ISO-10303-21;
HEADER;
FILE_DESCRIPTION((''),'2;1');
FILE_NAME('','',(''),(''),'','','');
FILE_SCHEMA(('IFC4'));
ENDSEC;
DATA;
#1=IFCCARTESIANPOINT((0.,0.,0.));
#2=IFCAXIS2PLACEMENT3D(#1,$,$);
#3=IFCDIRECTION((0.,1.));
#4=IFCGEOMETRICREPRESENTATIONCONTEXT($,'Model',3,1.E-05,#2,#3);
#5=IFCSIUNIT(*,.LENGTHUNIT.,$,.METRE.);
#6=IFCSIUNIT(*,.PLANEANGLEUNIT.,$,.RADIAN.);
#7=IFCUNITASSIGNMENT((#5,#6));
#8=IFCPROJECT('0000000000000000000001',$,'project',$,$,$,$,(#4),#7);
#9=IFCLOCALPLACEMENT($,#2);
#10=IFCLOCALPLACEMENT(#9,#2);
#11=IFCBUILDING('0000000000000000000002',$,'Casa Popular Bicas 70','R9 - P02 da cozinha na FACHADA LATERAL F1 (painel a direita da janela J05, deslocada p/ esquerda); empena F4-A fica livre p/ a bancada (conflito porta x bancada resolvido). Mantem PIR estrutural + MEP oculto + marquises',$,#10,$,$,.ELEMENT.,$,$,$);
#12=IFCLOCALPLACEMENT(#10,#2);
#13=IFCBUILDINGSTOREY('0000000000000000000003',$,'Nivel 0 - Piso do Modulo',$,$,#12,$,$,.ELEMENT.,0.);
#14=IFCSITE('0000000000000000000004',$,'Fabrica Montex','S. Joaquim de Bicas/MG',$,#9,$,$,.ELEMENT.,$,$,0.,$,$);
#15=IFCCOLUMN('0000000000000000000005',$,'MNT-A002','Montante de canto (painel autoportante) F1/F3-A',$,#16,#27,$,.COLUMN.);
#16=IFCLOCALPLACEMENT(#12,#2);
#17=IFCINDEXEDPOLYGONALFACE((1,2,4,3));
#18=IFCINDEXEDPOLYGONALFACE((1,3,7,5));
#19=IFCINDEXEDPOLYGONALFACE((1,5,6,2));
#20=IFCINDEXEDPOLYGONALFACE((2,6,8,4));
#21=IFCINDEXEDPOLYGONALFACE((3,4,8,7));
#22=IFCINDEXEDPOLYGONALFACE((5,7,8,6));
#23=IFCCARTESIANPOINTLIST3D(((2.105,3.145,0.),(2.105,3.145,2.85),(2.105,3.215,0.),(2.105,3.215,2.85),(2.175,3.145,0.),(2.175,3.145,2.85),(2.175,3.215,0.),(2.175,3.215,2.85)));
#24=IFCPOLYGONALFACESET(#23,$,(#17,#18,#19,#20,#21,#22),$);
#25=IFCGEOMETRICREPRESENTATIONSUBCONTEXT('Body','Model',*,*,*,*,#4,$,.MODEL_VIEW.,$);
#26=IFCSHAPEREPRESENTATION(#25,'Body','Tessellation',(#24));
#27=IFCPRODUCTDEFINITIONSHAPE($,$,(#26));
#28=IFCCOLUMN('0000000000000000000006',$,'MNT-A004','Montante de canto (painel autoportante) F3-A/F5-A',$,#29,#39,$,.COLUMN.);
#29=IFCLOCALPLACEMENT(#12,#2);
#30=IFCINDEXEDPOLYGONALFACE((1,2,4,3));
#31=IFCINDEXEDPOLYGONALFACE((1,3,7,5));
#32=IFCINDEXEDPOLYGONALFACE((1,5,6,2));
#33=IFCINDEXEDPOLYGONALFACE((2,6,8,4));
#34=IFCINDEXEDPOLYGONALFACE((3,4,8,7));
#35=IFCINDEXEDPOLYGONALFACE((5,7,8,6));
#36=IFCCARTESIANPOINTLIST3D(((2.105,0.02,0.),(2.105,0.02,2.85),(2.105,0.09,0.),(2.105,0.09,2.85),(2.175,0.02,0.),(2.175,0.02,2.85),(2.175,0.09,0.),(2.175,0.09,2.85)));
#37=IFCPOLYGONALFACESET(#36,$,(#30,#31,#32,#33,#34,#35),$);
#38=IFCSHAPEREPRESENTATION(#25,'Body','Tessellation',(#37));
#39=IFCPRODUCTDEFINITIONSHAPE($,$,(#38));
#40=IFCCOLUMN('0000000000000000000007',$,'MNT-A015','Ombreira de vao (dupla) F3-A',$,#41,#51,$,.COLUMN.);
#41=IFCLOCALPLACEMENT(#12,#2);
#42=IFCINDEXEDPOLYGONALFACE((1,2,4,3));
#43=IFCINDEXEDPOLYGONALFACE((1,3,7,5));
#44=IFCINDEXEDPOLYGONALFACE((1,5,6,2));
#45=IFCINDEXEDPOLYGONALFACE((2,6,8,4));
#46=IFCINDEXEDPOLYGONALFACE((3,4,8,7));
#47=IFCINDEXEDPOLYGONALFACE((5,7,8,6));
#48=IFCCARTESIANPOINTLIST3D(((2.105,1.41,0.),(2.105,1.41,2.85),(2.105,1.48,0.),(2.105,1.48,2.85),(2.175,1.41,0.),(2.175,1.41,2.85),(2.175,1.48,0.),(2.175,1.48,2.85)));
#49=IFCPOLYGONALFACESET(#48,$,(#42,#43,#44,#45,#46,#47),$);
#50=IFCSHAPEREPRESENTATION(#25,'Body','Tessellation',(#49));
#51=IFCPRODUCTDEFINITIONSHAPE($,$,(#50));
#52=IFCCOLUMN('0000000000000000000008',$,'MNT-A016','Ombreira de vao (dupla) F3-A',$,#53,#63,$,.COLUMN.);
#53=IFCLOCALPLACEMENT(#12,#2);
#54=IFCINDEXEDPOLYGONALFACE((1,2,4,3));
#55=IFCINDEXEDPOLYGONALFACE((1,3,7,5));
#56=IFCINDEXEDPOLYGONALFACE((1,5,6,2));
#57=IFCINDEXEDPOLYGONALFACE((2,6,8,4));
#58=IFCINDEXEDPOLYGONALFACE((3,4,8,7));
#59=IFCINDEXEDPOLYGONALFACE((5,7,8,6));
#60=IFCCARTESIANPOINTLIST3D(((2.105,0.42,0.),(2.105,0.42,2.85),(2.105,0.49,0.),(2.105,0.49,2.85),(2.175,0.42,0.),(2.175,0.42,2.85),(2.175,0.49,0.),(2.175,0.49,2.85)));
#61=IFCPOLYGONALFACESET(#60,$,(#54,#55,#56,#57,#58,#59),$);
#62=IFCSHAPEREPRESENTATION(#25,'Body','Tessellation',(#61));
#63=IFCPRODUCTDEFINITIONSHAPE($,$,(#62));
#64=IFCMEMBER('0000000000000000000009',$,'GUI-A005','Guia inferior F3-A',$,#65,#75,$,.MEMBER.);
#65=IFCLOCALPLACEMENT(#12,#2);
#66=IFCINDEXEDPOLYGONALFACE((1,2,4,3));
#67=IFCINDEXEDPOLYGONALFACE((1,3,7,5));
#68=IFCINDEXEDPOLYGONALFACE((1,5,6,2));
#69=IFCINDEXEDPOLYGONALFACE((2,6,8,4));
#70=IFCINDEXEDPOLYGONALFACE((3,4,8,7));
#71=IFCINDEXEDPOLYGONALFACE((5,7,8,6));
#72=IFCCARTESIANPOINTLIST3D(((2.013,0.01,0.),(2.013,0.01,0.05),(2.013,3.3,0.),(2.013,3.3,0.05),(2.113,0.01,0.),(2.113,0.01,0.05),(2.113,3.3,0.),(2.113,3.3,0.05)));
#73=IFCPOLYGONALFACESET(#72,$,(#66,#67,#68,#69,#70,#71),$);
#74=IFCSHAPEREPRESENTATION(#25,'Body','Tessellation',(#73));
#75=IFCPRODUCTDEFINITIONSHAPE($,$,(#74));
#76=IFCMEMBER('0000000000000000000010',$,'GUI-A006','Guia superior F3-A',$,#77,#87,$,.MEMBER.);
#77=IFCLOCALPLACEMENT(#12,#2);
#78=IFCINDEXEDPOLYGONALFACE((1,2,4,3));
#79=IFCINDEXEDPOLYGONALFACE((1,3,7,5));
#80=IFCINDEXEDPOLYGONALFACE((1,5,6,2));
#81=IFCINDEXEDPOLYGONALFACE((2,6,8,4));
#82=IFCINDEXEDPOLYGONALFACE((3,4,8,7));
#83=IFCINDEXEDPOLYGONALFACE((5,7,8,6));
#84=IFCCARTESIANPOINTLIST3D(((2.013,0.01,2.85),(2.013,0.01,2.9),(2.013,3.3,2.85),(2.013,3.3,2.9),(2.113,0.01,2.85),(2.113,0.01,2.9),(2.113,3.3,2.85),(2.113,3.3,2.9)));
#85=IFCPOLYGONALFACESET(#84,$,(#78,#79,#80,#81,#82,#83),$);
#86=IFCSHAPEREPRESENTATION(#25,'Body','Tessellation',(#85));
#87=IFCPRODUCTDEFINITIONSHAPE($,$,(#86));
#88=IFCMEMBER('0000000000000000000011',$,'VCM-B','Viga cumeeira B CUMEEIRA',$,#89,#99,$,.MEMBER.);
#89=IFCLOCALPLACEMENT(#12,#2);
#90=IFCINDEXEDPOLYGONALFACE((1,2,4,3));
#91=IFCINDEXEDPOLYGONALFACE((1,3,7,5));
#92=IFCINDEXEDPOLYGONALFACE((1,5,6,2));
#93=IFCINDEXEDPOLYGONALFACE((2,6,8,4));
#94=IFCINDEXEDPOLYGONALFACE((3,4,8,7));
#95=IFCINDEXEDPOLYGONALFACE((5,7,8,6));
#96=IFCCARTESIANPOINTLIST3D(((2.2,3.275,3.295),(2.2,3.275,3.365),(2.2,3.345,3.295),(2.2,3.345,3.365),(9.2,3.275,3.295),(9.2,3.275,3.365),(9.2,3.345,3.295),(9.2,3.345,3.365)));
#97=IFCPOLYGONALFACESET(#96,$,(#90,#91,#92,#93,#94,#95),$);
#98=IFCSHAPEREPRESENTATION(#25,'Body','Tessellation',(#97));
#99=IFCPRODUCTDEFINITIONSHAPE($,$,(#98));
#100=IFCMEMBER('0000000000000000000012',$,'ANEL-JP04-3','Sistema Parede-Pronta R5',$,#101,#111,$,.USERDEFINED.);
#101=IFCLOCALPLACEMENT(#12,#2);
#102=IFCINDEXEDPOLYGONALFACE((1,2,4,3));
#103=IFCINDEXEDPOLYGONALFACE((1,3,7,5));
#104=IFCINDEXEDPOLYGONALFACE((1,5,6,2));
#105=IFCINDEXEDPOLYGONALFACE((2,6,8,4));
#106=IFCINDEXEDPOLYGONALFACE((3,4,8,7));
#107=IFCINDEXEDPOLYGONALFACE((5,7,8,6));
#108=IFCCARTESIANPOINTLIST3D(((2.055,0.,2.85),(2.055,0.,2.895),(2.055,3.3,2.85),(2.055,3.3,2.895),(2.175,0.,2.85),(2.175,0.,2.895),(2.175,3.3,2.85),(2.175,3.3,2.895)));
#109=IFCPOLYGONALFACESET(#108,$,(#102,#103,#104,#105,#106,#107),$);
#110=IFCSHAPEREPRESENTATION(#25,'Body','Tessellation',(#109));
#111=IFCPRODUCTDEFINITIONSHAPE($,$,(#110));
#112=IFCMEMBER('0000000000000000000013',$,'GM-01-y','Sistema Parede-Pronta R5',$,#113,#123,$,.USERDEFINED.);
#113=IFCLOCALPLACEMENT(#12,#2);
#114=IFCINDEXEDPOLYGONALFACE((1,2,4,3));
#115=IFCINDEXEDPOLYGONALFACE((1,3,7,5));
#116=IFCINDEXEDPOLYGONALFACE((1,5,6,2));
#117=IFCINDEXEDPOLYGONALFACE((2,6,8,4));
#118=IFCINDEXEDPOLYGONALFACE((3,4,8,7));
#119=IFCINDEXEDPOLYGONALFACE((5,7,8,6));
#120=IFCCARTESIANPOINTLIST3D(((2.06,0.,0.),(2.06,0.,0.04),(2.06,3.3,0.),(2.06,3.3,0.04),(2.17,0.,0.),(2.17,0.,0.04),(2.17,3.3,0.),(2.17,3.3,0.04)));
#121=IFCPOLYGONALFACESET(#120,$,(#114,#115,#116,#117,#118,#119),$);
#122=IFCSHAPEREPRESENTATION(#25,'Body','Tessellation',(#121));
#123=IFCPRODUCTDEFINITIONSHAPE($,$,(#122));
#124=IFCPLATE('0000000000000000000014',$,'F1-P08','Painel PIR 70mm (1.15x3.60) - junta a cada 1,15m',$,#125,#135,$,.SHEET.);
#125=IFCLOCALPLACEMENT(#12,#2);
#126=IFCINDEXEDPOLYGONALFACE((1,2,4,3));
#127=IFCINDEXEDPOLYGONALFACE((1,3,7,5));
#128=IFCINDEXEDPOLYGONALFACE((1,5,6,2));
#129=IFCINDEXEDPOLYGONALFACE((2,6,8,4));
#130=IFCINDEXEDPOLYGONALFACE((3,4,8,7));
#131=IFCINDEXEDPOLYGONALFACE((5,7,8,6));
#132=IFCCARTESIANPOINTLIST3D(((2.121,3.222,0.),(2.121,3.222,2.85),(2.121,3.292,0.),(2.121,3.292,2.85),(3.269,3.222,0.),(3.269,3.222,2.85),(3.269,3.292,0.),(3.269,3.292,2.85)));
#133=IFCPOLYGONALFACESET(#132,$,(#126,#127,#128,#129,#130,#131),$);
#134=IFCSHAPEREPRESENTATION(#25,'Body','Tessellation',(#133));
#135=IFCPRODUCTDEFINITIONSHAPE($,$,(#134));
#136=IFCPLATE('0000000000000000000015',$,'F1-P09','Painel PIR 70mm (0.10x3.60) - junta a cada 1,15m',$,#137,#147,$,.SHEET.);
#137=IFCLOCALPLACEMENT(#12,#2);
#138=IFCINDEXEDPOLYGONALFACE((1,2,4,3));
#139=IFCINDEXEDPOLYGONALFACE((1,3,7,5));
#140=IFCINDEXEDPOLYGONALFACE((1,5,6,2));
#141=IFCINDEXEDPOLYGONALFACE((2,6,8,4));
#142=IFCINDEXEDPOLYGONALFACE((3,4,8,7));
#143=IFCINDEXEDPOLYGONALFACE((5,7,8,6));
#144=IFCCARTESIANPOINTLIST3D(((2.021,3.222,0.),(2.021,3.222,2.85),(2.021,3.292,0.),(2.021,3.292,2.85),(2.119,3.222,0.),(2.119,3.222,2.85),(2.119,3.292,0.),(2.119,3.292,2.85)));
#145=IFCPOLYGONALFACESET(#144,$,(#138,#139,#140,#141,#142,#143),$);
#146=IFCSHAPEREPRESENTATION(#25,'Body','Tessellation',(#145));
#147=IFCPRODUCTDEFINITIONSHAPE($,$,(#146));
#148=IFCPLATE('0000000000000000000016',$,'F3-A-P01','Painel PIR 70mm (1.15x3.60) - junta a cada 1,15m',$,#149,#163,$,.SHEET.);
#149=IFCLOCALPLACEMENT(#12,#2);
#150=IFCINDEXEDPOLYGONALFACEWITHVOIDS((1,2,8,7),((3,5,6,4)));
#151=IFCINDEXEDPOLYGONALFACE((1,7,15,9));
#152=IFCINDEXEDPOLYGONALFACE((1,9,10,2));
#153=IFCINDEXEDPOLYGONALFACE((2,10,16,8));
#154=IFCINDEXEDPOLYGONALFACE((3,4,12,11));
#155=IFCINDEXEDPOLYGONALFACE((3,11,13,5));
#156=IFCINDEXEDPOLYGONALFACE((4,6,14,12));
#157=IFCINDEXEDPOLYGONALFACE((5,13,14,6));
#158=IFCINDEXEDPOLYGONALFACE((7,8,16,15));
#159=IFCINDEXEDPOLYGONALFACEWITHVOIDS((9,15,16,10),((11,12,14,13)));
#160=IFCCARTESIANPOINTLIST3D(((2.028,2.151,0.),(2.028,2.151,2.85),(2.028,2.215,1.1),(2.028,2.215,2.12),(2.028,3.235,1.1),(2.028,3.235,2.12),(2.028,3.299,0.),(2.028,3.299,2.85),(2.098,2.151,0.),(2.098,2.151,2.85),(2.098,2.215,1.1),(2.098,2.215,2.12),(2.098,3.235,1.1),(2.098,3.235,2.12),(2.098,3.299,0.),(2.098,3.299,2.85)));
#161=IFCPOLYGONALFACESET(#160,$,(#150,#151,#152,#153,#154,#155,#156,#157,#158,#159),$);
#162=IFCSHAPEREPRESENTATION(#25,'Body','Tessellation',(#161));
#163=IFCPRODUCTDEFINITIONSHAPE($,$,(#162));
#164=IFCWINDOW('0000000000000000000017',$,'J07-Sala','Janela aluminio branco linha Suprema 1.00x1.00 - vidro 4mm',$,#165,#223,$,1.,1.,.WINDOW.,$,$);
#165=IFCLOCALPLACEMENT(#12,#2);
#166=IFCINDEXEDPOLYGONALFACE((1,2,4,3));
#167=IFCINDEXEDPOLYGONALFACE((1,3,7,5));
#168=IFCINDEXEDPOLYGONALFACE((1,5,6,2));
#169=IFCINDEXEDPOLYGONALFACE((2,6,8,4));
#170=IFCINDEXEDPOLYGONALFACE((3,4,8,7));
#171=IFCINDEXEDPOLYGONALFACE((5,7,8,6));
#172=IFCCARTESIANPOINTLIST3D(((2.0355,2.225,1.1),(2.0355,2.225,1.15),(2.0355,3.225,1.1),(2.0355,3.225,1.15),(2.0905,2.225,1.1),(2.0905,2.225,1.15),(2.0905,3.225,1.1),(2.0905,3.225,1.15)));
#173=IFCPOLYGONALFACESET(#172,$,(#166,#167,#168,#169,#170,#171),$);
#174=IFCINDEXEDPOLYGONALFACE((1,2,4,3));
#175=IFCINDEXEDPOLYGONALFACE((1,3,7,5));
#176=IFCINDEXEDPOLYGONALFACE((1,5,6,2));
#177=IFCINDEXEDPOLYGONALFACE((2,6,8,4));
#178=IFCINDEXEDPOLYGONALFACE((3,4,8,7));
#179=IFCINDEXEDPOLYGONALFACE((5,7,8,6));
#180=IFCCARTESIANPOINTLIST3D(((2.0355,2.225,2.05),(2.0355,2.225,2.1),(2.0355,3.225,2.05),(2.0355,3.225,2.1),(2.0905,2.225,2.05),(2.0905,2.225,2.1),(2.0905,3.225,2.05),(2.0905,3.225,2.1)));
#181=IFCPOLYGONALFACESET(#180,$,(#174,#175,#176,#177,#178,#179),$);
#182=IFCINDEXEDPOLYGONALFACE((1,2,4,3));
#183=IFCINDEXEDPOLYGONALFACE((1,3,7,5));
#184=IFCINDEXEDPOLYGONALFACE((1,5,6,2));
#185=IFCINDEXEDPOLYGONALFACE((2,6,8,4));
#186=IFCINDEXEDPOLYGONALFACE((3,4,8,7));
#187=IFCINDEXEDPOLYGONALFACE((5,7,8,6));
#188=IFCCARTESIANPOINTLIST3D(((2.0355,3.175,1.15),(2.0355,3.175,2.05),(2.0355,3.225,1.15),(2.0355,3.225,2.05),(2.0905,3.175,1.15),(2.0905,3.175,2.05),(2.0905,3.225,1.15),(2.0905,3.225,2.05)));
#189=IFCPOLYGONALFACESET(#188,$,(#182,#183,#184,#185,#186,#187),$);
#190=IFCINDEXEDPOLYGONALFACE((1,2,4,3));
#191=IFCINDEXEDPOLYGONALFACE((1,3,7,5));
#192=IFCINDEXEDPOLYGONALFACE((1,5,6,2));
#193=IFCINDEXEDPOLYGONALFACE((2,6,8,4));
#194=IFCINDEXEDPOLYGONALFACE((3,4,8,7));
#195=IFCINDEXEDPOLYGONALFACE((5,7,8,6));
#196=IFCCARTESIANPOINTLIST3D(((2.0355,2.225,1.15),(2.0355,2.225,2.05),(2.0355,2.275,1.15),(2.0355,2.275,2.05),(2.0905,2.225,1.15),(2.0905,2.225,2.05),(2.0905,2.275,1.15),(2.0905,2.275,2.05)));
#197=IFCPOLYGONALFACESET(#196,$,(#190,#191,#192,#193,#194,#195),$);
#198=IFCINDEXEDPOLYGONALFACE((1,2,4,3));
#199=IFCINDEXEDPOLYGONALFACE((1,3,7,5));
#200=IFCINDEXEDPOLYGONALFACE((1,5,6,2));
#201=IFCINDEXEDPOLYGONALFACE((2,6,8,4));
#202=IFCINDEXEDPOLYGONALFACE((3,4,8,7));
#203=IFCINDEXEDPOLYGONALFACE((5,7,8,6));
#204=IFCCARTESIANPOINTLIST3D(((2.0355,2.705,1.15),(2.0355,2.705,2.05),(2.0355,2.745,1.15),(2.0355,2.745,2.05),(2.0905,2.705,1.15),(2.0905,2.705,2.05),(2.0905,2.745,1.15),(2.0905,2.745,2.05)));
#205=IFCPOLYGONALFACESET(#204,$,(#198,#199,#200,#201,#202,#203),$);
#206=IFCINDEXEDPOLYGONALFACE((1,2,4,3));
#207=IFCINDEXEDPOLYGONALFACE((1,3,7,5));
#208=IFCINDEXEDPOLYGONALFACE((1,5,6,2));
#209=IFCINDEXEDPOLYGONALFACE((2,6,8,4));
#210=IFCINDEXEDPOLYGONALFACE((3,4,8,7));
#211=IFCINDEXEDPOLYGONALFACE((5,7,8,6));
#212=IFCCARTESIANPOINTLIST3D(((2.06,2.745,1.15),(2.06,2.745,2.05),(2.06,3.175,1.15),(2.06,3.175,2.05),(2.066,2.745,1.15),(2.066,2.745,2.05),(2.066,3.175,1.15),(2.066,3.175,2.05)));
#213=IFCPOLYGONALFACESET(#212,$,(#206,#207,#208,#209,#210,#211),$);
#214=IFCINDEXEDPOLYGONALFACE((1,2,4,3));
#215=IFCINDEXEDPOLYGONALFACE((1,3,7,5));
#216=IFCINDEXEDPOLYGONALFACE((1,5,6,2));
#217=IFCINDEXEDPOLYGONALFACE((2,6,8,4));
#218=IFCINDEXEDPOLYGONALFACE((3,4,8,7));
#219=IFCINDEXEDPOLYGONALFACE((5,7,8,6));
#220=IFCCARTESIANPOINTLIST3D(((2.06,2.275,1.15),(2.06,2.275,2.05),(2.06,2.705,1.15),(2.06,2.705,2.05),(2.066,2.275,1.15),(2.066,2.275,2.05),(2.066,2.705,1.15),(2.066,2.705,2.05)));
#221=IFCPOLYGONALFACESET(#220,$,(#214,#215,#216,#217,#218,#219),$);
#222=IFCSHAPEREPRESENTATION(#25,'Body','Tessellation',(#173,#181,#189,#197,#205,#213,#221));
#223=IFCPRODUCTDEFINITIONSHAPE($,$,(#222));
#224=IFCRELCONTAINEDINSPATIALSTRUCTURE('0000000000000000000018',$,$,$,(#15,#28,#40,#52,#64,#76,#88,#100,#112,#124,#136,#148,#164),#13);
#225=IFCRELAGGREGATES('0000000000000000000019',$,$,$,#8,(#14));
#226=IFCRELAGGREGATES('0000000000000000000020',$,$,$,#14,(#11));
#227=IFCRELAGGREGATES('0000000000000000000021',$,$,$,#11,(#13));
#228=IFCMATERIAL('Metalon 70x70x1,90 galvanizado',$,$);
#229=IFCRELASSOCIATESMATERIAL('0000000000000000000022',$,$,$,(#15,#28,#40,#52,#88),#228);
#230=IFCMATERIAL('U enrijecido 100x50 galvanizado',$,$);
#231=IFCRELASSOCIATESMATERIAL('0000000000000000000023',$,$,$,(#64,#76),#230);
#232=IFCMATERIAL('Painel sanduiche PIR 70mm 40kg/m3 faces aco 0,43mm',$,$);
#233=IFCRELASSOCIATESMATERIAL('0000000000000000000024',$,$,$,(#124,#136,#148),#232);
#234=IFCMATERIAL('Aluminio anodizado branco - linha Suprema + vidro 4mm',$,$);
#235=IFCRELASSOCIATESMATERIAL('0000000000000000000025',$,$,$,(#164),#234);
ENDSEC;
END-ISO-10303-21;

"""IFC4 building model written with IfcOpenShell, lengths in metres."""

from ifc_helpers import new_model, si_unit, direction, frame, frame_2d, origin, origin_2d, place, context, subcontext, project, spatial, rectangle, extrude, material, element, fill, save


model = new_model("IFC4")

# Units and contexts
model_context = context("Model", 3, precision=1e-05, world=origin(), true_north=direction((0.0, 1.0)))
body_context = subcontext(model_context, "Body", "Model", "MODEL_VIEW")
ifc_project = project(units=[si_unit("LENGTHUNIT", "METRE"), si_unit("PLANEANGLEUNIT", "RADIAN")], contexts=[model_context])

# Site, building, storey
site_placement = place(None, origin())
site = spatial("IfcSite", under=ifc_project, at=site_placement, Name="Fabrica Montex", Description="S. Joaquim de Bicas/MG", CompositionType="ELEMENT", RefElevation=0.0)
building_placement = place(site_placement, origin())
building = spatial("IfcBuilding", under=site, at=building_placement, Name="Casa Popular Bicas 70", Description="R9 - P02 da cozinha na FACHADA LATERAL F1 (painel a direita da janela J05, deslocada p/ esquerda); empena F4-A fica livre p/ a bancada (conflito porta x bancada resolvido). Mantem PIR estrutural + MEP oculto + marquises", CompositionType="ELEMENT")
storey_placement = place(building_placement, origin())
storey = spatial("IfcBuildingStorey", under=building, at=storey_placement, Name="Nivel 0 - Piso do Modulo", CompositionType="ELEMENT", Elevation=0.0)

# Columns
ifc_material_1 = material(Name="Metalon 70x70x1,90 galvanizado")
for number, where, z_axis, x_axis, name, description in (
    (1, (2.14, 3.18, 0.0), (0.0, 0.0, 1.0), (-1.0, 0.0, 0.0), "MNT-A002", "Montante de canto (painel autoportante) F1/F3-A"),
    (2, (2.14, 0.055, 0.0), (0.0, 0.0, 1.0), (-1.0, 0.0, 0.0), "MNT-A004", "Montante de canto (painel autoportante) F3-A/F5-A"),
    (3, (2.14, 1.445, 0.0), (0.0, 0.0, 1.0), (-1.0, 0.0, 0.0), "MNT-A015", "Ombreira de vao (dupla) F3-A"),
    (4, (2.14, 0.455, 0.0), (0.0, 0.0, 1.0), (-1.0, 0.0, 0.0), "MNT-A016", "Ombreira de vao (dupla) F3-A"),
):
    element("IfcColumn", number, at=place(None, frame(where, z_axis=z_axis, x_axis=x_axis)), inside=storey, material=ifc_material_1, Name=name, Description=description, PredefinedType="COLUMN", context=body_context, shape_type="SweptSolid", body=[
        extrude(rectangle(XDim=0.07, YDim=0.07, at=origin_2d()), origin(), (0.0, 0.0, 1.0), 2.85),
    ])

# Members
ifc_material_2 = material(Name="U enrijecido 100x50 galvanizado")
for number, where, z_axis, x_axis, name, description in (
    (5, (2.063, 3.3, 0.025), (0.0, -1.0, 0.0), (0.0, 0.0, 1.0), "GUI-A005", "Guia inferior F3-A"),
    (6, (2.063, 3.3, 2.875), (0.0, -1.0, 0.0), (0.0, 0.0, 1.0), "GUI-A006", "Guia superior F3-A"),
):
    element("IfcMember", number, at=place(None, frame(where, z_axis=z_axis, x_axis=x_axis)), inside=storey, material=ifc_material_2, Name=name, Description=description, PredefinedType="MEMBER", context=body_context, shape_type="SweptSolid", body=[
        extrude(rectangle(XDim=0.05, YDim=0.1, at=origin_2d()), origin(), (0.0, 0.0, 1.0), 3.29),
    ])
member_1_placement = place(storey_placement, frame((2.2, 3.31, 3.33), z_axis=(1.0, 0.0, 0.0), x_axis=(0.0, 0.0, 1.0)))
element("IfcMember", 7, at=member_1_placement, inside=storey, material=ifc_material_1, Name="VCM-B", Description="Viga cumeeira B CUMEEIRA", PredefinedType="MEMBER", context=body_context, shape_type="SweptSolid", body=[
    extrude(rectangle(XDim=0.07, YDim=0.07, at=origin_2d()), origin(), (0.0, 0.0, 1.0), 7.0),
])
member_2_placement = place(storey_placement, frame((2.115, 1.65, 2.85)))
element("IfcMember", 8, at=member_2_placement, inside=storey, Name="ANEL-JP04-3", Description="Sistema Parede-Pronta R5", PredefinedType="USERDEFINED", context=body_context, shape_type="SweptSolid", body=[
    extrude(rectangle(XDim=0.12, YDim=3.3, at=origin_2d()), origin(), (0.0, 0.0, 1.0), 0.045),
])
member_3_placement = place(storey_placement, frame((2.115, 1.65, 0.0)))
element("IfcMember", 9, at=member_3_placement, inside=storey, Name="GM-01-y", Description="Sistema Parede-Pronta R5", PredefinedType="USERDEFINED", context=body_context, shape_type="SweptSolid", body=[
    extrude(rectangle(XDim=0.11, YDim=3.3, at=origin_2d()), origin(), (0.0, 0.0, 1.0), 0.04),
])

# Plates
ifc_material_3 = material(Name="Painel sanduiche PIR 70mm 40kg/m3 faces aco 0,43mm")
plate_1_placement = place(None, frame((3.269, 3.257, 0.0), z_axis=(0.0, 0.0, 1.0), x_axis=(-1.0, 0.0, 0.0)))
element("IfcPlate", 10, at=plate_1_placement, inside=storey, material=ifc_material_3, Name="F1-P08", Description="Painel PIR 70mm (1.15x3.60) - junta a cada 1,15m", PredefinedType="SHEET", context=body_context, shape_type="SweptSolid", body=[
    extrude(rectangle(XDim=1.148, YDim=0.07, at=frame_2d((0.574, 0.0))), origin(), (0.0, 0.0, 1.0), 2.85),
])
plate_2_placement = place(None, frame((2.119, 3.257, 0.0), z_axis=(0.0, 0.0, 1.0), x_axis=(-1.0, 0.0, 0.0)))
element("IfcPlate", 11, at=plate_2_placement, inside=storey, material=ifc_material_3, Name="F1-P09", Description="Painel PIR 70mm (0.10x3.60) - junta a cada 1,15m", PredefinedType="SHEET", context=body_context, shape_type="SweptSolid", body=[
    extrude(rectangle(XDim=0.098, YDim=0.07, at=frame_2d((0.049, 0.0))), origin(), (0.0, 0.0, 1.0), 2.85),
])

# Plate, opening, window
plate_3_placement = place(None, frame((2.063, 3.299, 0.0), z_axis=(0.0, 0.0, 1.0), x_axis=(0.0, -1.0, 0.0)))
plate_3 = element("IfcPlate", 12, at=plate_3_placement, inside=storey, material=ifc_material_3, Name="F3-A-P01", Description="Painel PIR 70mm (1.15x3.60) - junta a cada 1,15m", PredefinedType="SHEET", context=body_context, shape_type="SweptSolid", body=[
    extrude(rectangle(XDim=1.148, YDim=0.07, at=frame_2d((0.574, 0.0))), origin(), (0.0, 0.0, 1.0), 2.85),
])
opening_1_placement = place(None, frame((2.063, 3.225, 1.1), z_axis=(0.0, 0.0, 1.0), x_axis=(0.0, -1.0, 0.0)))
opening_1 = element("IfcOpeningElement", 13, at=opening_1_placement, cuts=plate_3, PredefinedType="OPENING", context=body_context, shape_type="SweptSolid", body=[
    extrude(rectangle(XDim=1.02, YDim=0.3, at=frame_2d((0.5, 0.0))), origin(), (0.0, 0.0, 1.0), 1.02),
])
ifc_material_4 = material(Name="Aluminio anodizado branco - linha Suprema + vidro 4mm")
window_placement = place(None, frame((2.063, 3.225, 1.1), z_axis=(0.0, 0.0, 1.0), x_axis=(0.0, -1.0, 0.0)))
window = element("IfcWindow", 14, at=window_placement, inside=storey, material=ifc_material_4, Name="J07-Sala", Description="Janela aluminio branco linha Suprema 1.00x1.00 - vidro 4mm", OverallHeight=1.0, OverallWidth=1.0, PredefinedType="WINDOW", context=body_context, shape_type="SweptSolid", body=[
    extrude(rectangle(XDim=1.0, YDim=0.055, at=frame_2d((0.5, 0.0))), origin(), (0.0, 0.0, 1.0), 0.05),
    extrude(rectangle(XDim=1.0, YDim=0.055, at=frame_2d((0.5, 0.0))), frame((0.0, 0.0, 0.95)), (0.0, 0.0, 1.0), 0.05),
    extrude(rectangle(XDim=0.05, YDim=0.055, at=frame_2d((0.025, 0.0))), frame((0.0, 0.0, 0.05)), (0.0, 0.0, 1.0), 0.9),
    extrude(rectangle(XDim=0.05, YDim=0.055, at=frame_2d((0.975, 0.0))), frame((0.0, 0.0, 0.05)), (0.0, 0.0, 1.0), 0.9),
    extrude(rectangle(XDim=0.04, YDim=0.055, at=frame_2d((0.5, 0.0))), frame((0.0, 0.0, 0.05)), (0.0, 0.0, 1.0), 0.9),
    extrude(rectangle(XDim=0.43, YDim=0.006, at=frame_2d((0.265, 0.0))), frame((0.0, 0.0, 0.05)), (0.0, 0.0, 1.0), 0.9),
    extrude(rectangle(XDim=0.43, YDim=0.006, at=frame_2d((0.735, 0.0))), frame((0.0, 0.0, 0.05)), (0.0, 0.0, 1.0), 0.9),
])
fill(opening_1, window)

save(model, "model.ifc")
